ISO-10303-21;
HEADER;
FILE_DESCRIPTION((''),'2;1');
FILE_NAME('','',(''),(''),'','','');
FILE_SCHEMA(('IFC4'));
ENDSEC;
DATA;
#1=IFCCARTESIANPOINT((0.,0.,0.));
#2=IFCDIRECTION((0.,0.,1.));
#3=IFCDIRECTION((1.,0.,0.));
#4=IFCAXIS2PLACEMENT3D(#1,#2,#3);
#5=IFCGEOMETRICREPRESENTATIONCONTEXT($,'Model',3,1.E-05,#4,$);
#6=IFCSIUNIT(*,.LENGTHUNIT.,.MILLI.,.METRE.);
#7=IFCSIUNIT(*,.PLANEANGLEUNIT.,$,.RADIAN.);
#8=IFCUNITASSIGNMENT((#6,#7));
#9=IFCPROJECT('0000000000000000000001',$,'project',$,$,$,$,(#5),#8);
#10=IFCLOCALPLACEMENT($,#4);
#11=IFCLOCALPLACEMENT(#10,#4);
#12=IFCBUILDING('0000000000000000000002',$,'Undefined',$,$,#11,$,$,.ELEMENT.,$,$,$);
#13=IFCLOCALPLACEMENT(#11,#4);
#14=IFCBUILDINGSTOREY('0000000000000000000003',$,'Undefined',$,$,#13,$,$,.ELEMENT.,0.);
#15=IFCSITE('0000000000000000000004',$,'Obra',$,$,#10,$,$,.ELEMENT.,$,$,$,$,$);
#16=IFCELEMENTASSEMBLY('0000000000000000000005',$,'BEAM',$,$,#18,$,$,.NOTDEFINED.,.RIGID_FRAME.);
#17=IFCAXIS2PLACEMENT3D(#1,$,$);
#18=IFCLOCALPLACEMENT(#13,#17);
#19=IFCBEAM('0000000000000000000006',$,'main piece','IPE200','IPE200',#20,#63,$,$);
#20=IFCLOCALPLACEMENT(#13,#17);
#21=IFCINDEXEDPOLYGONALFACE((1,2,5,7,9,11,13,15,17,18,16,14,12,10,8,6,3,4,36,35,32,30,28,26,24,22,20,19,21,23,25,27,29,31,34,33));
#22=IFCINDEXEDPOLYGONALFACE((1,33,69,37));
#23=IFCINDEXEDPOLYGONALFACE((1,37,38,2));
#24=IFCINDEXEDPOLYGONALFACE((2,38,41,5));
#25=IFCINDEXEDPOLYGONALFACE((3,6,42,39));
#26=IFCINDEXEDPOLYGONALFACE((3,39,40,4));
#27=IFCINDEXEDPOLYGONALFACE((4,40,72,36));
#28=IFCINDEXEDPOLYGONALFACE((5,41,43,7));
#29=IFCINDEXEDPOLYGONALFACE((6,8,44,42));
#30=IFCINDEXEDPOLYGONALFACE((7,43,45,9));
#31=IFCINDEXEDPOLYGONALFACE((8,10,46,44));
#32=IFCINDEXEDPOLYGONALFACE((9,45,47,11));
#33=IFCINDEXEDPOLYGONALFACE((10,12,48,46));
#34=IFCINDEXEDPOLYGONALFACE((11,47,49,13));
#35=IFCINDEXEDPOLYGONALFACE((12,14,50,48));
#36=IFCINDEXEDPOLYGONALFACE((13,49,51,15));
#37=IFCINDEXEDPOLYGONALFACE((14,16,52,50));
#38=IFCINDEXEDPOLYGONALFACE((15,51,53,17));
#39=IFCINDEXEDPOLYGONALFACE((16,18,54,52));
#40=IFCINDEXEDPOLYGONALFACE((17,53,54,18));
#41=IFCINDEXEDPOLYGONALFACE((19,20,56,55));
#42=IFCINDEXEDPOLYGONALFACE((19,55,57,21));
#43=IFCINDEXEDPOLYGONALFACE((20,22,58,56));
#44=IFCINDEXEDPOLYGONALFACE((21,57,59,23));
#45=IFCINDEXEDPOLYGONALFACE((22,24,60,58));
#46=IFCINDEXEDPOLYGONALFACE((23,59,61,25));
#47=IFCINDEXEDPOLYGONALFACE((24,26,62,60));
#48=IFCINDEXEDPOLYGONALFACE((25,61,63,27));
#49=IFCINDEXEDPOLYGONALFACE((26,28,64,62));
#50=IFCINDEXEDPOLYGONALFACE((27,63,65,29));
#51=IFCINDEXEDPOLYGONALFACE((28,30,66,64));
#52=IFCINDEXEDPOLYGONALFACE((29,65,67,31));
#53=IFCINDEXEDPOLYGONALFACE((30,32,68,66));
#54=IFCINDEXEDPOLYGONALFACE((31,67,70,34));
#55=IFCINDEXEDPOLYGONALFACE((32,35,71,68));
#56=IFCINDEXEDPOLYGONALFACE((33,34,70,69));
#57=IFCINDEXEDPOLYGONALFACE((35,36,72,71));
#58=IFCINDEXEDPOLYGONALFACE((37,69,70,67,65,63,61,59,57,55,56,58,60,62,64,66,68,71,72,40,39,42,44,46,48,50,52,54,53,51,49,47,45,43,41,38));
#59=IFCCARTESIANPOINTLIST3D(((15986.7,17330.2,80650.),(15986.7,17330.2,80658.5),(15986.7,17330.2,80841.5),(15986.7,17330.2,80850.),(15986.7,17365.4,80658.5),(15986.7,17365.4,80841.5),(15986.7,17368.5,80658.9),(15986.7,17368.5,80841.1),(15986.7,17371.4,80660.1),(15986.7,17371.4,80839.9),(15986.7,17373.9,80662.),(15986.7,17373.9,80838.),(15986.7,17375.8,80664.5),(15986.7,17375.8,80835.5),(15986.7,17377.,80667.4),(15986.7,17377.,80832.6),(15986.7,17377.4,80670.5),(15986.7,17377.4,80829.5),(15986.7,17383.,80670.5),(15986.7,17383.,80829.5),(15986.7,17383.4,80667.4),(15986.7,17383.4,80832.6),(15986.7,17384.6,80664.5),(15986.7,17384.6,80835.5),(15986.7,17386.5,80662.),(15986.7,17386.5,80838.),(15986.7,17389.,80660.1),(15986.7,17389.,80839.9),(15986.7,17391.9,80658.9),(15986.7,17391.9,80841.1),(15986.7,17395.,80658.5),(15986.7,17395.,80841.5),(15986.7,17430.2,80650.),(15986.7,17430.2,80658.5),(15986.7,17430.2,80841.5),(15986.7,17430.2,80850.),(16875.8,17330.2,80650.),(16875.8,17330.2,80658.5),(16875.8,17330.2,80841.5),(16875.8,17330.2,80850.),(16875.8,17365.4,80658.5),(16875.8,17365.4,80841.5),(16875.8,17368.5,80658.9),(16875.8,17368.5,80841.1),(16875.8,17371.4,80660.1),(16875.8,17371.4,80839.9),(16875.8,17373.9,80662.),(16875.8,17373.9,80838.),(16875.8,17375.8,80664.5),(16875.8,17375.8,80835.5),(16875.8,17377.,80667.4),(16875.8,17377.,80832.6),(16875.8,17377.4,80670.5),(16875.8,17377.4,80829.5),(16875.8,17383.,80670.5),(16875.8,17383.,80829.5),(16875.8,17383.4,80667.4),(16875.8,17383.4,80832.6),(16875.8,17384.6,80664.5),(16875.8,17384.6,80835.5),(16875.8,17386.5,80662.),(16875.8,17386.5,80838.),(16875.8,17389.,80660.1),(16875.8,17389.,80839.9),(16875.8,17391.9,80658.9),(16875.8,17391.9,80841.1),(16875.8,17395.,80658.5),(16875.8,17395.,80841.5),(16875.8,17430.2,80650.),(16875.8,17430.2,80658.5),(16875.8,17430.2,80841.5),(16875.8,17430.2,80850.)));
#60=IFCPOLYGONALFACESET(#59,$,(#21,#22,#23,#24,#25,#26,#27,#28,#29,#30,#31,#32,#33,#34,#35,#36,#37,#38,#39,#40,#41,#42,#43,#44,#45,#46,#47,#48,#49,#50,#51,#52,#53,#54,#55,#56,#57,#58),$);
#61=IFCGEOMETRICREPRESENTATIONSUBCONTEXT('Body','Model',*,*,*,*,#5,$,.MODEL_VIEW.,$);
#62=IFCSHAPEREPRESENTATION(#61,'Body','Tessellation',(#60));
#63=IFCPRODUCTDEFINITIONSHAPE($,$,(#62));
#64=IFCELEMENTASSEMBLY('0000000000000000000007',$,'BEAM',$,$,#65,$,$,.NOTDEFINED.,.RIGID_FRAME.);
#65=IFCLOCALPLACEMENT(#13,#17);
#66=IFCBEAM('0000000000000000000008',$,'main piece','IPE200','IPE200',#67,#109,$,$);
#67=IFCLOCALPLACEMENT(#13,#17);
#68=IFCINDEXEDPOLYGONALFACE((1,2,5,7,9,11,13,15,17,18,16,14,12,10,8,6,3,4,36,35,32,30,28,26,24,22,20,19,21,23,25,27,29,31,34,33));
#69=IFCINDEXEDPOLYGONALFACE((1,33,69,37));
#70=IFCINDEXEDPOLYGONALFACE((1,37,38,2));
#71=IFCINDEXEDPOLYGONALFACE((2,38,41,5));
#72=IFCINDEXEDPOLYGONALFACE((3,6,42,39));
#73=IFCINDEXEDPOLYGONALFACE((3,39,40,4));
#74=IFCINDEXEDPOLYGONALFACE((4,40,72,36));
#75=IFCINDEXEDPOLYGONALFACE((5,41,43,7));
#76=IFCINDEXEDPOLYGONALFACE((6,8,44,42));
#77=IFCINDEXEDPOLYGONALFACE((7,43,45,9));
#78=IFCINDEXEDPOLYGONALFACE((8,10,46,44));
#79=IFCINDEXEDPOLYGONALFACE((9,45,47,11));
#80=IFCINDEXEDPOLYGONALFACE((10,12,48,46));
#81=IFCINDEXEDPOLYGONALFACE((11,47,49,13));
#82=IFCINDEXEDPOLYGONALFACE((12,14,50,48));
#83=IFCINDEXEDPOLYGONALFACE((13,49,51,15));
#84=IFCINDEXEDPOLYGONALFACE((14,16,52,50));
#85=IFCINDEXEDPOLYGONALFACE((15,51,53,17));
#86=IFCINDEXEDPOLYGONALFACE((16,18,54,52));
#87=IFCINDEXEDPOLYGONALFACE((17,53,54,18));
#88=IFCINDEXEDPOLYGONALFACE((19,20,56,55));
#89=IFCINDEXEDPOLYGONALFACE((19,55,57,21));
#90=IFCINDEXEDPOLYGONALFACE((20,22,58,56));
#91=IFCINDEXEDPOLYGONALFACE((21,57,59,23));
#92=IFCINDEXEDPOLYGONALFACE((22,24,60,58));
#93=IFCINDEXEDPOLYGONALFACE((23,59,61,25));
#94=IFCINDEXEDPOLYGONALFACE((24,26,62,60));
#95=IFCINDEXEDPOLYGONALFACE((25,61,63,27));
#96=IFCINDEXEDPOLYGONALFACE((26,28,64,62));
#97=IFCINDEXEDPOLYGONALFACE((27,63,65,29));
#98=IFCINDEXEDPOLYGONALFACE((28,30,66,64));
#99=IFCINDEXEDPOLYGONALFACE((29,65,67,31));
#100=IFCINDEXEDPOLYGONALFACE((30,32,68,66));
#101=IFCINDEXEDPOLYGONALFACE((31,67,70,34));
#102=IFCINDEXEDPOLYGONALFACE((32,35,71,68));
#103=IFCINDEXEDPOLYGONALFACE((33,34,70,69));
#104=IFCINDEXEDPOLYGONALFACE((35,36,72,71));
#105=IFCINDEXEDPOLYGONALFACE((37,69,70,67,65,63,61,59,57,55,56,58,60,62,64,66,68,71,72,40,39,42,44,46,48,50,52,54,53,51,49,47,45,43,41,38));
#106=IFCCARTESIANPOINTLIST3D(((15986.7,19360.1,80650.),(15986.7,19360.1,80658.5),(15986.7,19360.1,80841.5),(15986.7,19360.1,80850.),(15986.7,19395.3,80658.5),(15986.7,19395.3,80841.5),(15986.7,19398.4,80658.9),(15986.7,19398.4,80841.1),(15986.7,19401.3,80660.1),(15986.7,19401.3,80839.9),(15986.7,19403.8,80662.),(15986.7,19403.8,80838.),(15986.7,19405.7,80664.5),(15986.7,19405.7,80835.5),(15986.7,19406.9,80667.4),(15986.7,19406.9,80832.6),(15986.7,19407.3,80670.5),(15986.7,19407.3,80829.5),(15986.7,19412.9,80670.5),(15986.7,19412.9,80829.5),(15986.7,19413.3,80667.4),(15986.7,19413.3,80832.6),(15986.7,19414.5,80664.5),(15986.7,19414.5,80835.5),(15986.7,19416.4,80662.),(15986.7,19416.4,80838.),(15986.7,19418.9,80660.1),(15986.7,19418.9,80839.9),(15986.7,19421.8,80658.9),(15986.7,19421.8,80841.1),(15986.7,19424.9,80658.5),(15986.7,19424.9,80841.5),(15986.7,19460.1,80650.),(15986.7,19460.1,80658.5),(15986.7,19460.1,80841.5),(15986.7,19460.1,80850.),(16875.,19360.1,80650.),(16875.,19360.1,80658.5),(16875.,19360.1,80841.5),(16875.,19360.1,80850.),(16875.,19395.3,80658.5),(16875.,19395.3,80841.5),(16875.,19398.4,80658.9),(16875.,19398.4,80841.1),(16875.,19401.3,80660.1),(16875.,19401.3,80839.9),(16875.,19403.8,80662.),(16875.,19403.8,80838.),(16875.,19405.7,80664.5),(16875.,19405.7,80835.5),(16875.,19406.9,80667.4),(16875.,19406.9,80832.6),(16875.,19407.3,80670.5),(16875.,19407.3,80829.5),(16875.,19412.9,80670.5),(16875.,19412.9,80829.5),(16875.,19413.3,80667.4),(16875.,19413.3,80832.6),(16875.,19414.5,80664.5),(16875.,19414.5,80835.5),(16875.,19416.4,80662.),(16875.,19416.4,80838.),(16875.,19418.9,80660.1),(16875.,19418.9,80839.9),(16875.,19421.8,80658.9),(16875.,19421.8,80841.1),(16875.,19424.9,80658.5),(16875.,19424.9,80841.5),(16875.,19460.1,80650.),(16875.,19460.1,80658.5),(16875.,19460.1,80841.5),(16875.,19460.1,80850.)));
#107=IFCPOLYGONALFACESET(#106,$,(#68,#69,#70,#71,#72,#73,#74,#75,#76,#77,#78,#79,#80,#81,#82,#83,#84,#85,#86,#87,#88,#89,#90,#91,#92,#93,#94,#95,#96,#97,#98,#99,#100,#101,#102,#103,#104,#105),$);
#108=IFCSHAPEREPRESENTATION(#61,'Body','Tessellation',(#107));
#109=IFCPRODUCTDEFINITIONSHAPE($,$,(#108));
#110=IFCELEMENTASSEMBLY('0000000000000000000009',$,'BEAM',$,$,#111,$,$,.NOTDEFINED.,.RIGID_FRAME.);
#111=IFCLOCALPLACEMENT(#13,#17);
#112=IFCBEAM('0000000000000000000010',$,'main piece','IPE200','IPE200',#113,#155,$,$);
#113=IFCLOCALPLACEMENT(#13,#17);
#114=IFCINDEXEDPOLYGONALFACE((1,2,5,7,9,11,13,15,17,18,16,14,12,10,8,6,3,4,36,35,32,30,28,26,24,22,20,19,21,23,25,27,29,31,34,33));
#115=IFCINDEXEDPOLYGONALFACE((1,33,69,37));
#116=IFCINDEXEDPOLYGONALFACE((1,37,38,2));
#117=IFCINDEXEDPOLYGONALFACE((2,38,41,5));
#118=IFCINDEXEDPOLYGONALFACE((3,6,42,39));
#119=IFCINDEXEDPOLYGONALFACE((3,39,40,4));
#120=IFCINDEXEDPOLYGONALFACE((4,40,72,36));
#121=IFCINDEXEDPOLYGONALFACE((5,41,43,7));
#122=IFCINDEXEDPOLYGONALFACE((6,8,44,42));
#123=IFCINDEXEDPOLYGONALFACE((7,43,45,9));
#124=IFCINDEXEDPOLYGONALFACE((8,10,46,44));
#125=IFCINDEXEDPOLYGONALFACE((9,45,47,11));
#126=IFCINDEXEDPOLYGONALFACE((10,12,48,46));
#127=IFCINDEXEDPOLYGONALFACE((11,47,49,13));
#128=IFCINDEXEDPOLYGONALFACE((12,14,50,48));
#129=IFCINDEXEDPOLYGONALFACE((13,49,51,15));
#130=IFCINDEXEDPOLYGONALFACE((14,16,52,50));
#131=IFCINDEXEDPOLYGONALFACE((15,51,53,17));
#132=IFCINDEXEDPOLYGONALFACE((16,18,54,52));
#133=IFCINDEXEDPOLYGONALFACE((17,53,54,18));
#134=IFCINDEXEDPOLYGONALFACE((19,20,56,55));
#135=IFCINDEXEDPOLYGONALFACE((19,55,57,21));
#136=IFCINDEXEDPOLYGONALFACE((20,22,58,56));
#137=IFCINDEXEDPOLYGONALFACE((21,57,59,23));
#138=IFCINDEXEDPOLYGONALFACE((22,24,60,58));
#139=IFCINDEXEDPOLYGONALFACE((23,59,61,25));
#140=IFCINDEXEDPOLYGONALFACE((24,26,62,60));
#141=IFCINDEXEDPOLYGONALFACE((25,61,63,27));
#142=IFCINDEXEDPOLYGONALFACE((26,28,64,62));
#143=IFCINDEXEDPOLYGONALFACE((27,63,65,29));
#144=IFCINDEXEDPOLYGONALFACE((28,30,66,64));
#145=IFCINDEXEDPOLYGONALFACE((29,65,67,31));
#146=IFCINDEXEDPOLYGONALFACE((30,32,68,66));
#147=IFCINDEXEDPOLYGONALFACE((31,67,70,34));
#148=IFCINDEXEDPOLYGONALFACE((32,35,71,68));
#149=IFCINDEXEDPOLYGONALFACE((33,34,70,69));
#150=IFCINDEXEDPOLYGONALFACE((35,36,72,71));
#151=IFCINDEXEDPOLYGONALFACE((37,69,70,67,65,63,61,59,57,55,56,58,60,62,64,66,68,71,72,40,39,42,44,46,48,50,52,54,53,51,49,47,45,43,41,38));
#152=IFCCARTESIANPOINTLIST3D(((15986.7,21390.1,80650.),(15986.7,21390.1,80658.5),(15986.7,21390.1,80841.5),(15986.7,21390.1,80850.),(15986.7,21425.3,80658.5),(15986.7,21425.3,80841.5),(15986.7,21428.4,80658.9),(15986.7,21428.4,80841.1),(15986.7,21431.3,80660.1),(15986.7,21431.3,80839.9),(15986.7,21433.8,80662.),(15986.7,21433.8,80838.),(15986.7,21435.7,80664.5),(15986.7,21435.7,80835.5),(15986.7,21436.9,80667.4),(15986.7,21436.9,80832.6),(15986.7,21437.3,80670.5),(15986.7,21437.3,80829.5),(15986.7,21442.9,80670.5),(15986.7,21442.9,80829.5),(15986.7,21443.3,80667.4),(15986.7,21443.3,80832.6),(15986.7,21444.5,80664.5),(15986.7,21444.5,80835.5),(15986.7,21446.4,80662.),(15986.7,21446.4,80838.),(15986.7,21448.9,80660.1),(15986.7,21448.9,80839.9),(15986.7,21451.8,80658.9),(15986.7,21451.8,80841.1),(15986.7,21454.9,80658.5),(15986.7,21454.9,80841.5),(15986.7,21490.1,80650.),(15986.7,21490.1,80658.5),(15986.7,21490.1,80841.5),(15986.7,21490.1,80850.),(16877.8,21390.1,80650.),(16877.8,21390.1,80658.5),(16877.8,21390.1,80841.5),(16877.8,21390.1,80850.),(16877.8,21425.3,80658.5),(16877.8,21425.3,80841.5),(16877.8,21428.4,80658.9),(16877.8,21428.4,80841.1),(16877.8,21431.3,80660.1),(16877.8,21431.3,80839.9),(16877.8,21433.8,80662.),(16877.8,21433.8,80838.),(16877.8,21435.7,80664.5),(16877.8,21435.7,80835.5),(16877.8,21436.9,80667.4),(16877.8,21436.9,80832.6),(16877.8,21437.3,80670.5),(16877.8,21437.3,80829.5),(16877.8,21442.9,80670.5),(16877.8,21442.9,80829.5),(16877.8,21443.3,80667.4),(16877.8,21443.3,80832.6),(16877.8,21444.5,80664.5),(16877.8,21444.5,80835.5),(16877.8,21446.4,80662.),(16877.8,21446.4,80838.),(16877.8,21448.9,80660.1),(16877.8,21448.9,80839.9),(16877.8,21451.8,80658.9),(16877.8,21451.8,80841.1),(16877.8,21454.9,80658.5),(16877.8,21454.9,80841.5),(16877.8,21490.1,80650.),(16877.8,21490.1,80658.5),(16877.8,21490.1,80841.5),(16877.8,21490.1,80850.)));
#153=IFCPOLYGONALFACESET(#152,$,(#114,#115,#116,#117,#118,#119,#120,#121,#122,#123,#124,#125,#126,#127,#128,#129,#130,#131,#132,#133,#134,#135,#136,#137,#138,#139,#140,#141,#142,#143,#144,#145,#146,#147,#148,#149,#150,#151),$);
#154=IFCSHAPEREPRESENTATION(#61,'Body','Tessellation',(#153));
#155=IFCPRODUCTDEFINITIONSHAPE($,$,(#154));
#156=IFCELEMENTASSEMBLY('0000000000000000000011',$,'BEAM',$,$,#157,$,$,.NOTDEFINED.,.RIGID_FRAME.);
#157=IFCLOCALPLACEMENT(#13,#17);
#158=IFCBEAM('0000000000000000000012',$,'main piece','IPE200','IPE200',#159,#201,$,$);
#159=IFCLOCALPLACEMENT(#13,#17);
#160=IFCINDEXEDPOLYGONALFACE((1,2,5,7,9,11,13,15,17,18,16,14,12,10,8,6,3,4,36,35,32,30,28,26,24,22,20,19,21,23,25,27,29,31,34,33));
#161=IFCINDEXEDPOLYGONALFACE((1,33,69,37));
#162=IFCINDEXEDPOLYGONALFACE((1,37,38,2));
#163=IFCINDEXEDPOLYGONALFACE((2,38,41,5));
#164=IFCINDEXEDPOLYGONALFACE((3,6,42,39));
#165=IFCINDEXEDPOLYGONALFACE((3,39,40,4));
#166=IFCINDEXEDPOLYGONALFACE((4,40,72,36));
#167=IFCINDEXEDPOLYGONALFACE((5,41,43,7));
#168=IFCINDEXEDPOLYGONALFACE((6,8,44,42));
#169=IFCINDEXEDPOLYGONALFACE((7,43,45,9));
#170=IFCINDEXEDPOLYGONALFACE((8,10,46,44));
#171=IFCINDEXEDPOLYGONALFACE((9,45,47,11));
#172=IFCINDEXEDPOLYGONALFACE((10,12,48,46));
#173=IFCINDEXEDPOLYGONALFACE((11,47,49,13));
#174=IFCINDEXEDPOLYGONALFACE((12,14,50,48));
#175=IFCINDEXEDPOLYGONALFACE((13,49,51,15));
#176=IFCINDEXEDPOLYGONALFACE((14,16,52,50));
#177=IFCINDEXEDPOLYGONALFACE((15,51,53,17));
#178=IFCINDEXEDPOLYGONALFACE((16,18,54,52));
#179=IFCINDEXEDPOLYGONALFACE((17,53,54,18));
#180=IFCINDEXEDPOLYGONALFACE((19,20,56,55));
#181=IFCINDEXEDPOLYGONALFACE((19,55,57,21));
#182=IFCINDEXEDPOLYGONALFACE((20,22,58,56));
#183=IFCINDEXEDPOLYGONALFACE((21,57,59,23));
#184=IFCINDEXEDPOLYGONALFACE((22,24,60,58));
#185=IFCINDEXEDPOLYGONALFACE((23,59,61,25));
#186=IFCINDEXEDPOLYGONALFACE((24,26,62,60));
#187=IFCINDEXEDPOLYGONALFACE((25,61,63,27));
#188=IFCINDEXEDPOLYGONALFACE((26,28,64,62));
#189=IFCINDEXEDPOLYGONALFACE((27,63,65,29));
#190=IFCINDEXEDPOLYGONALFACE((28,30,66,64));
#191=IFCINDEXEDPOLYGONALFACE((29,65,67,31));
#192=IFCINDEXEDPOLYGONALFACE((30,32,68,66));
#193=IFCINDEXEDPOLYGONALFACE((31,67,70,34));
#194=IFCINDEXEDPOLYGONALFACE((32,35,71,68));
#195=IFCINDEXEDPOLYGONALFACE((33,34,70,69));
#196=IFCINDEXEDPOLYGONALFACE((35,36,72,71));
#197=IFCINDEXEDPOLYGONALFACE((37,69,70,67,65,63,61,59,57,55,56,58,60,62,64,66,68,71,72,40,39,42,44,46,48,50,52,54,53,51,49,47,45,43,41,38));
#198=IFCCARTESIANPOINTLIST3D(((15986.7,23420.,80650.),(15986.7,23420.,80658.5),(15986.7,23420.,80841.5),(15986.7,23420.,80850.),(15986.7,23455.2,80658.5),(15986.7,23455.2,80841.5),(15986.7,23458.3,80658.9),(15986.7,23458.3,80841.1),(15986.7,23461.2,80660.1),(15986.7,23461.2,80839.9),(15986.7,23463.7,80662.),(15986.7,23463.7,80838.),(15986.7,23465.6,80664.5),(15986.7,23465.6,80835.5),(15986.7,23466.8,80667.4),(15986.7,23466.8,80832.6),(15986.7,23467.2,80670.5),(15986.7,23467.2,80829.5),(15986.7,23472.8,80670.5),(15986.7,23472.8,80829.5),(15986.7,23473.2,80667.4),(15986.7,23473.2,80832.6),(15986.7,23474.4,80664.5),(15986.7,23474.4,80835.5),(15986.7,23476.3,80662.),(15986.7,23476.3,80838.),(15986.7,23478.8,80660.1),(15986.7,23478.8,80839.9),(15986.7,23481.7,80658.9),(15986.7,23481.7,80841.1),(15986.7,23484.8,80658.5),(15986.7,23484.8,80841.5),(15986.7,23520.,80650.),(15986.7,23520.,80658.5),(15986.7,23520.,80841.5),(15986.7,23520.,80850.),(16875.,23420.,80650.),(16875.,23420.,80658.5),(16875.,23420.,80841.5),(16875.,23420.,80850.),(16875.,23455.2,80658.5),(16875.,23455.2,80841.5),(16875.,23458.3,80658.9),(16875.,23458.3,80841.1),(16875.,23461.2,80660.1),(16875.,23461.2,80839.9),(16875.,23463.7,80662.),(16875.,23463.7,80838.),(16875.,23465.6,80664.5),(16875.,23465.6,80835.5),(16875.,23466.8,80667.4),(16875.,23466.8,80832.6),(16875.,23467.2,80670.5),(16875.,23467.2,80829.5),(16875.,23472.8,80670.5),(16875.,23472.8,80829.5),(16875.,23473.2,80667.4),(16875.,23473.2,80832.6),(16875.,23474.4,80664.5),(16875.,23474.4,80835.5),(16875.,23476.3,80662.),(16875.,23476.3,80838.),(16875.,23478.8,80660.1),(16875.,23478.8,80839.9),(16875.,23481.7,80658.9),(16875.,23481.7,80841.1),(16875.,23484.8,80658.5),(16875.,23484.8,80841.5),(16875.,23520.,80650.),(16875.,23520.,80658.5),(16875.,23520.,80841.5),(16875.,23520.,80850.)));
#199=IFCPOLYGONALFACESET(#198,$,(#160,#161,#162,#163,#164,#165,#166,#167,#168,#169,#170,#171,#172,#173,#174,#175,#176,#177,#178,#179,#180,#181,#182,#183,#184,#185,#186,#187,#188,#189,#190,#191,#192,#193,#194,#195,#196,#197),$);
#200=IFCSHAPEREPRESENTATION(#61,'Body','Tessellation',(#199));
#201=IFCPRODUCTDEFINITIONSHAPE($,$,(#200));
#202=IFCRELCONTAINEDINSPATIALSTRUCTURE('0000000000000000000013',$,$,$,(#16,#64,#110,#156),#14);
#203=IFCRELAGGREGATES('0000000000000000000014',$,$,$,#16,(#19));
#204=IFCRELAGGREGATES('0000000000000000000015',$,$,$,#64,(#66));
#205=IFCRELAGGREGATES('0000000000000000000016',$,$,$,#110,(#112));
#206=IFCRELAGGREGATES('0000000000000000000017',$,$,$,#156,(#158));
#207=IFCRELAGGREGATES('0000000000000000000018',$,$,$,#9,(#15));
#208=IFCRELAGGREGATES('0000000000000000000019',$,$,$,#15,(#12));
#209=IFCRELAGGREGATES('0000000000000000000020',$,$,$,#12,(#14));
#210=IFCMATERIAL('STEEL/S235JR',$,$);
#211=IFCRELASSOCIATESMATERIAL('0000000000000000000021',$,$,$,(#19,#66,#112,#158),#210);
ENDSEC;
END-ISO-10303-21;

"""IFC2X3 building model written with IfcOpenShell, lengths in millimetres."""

from ifc_helpers import new_model, si_unit, frame, origin_with_axes, origin_2d_with_axis, place, context, subcontext, project, spatial, i_section, extrude, material, element, aggregate, save


model = new_model("IFC2X3")

# Units and contexts
model_context = context("Model", 3, precision=1e-05, world=origin_with_axes())
body_context = subcontext(model_context, "Body", "Model", "MODEL_VIEW")
ifc_project = project(units=[si_unit("LENGTHUNIT", "METRE", prefix="MILLI"), si_unit("PLANEANGLEUNIT", "RADIAN")], contexts=[model_context])

# Site, building, storey
site_placement = place(None, origin_with_axes())
site = spatial("IfcSite", under=ifc_project, at=site_placement, Name="Obra", CompositionType="ELEMENT")
building_placement = place(site_placement, origin_with_axes())
building = spatial("IfcBuilding", under=site, at=building_placement, Name="Undefined", CompositionType="ELEMENT")
storey_placement = place(building_placement, origin_with_axes())
storey = spatial("IfcBuildingStorey", under=building, at=storey_placement, Name="Undefined", CompositionType="ELEMENT", Elevation=0.0)

# Element assemblies, beams
ifc_material = material(Name="STEEL/S235JR")
assembly_1_placement = place(storey_placement, origin_with_axes())
assembly_1 = element("IfcElementAssembly", 1, at=assembly_1_placement, inside=storey, Name="BEAM", AssemblyPlace="NOTDEFINED", PredefinedType="RIGID_FRAME")
beam_1_placement = place(assembly_1_placement, frame((16875.8, 17380.2, 80750.0), z_axis=(0.0, 0.0, 1.0), x_axis=(-1.0, 0.0, 0.0)))
beam_1 = element("IfcBeam", 2, at=beam_1_placement, material=ifc_material, Name="main piece", Description="IPE200", ObjectType="IPE200", context=body_context, shape_type="SweptSolid", body=[
    extrude(i_section(OverallWidth=100.0, OverallDepth=200.0, WebThickness=5.6, FlangeThickness=8.5, FilletRadius=12.0, at=origin_2d_with_axis()), frame((889.1, 0.0, 0.0), z_axis=(-1.0, 0.0, 0.0), x_axis=(0.0, -1.0, 0.0)), (0.0, 0.0, 1.0), 889.1),
])
aggregate(assembly_1, [beam_1])
assembly_2_placement = place(storey_placement, origin_with_axes())
assembly_2 = element("IfcElementAssembly", 3, at=assembly_2_placement, inside=storey, Name="BEAM", AssemblyPlace="NOTDEFINED", PredefinedType="RIGID_FRAME")
beam_2_placement = place(assembly_2_placement, frame((15986.7, 19410.1, 80750.0), z_axis=(0.0, 0.0, 1.0), x_axis=(1.0, 0.0, 0.0)))
beam_2 = element("IfcBeam", 4, at=beam_2_placement, material=ifc_material, Name="main piece", Description="IPE200", ObjectType="IPE200", context=body_context, shape_type="SweptSolid", body=[
    extrude(i_section(OverallWidth=100.0, OverallDepth=200.0, WebThickness=5.6, FlangeThickness=8.5, FilletRadius=12.0, at=origin_2d_with_axis()), frame((888.3, 0.0, 0.0), z_axis=(-1.0, 0.0, 0.0), x_axis=(0.0, -1.0, 0.0)), (0.0, 0.0, 1.0), 888.3),
])
aggregate(assembly_2, [beam_2])
assembly_3_placement = place(storey_placement, origin_with_axes())
assembly_3 = element("IfcElementAssembly", 5, at=assembly_3_placement, inside=storey, Name="BEAM", AssemblyPlace="NOTDEFINED", PredefinedType="RIGID_FRAME")
beam_3_placement = place(assembly_3_placement, frame((16877.8, 21440.1, 80750.0), z_axis=(0.0, 0.0, 1.0), x_axis=(-1.0, -0.000037, 0.0)))
beam_3 = element("IfcBeam", 6, at=beam_3_placement, material=ifc_material, Name="main piece", Description="IPE200", ObjectType="IPE200", context=body_context, shape_type="SweptSolid", body=[
    extrude(i_section(OverallWidth=100.0, OverallDepth=200.0, WebThickness=5.6, FlangeThickness=8.5, FilletRadius=12.0, at=origin_2d_with_axis()), frame((891.1, 0.0, 0.0), z_axis=(-1.0, 0.0, 0.0), x_axis=(0.0, -1.0, 0.0)), (0.0, 0.0, 1.0), 891.1),
])
aggregate(assembly_3, [beam_3])
assembly_4_placement = place(storey_placement, origin_with_axes())
assembly_4 = element("IfcElementAssembly", 7, at=assembly_4_placement, inside=storey, Name="BEAM", AssemblyPlace="NOTDEFINED", PredefinedType="RIGID_FRAME")
beam_4_placement = place(assembly_4_placement, frame((15986.7, 23470.0, 80750.0), z_axis=(0.0, 0.0, 1.0), x_axis=(1.0, 0.0, 0.0)))
beam_4 = element("IfcBeam", 8, at=beam_4_placement, material=ifc_material, Name="main piece", Description="IPE200", ObjectType="IPE200", context=body_context, shape_type="SweptSolid", body=[
    extrude(i_section(OverallWidth=100.0, OverallDepth=200.0, WebThickness=5.6, FlangeThickness=8.5, FilletRadius=12.0, at=origin_2d_with_axis()), frame((888.3, 0.0, 0.0), z_axis=(-1.0, 0.0, 0.0), x_axis=(0.0, -1.0, 0.0)), (0.0, 0.0, 1.0), 888.3),
])
aggregate(assembly_4, [beam_4])

save(model, "model.ifc")
